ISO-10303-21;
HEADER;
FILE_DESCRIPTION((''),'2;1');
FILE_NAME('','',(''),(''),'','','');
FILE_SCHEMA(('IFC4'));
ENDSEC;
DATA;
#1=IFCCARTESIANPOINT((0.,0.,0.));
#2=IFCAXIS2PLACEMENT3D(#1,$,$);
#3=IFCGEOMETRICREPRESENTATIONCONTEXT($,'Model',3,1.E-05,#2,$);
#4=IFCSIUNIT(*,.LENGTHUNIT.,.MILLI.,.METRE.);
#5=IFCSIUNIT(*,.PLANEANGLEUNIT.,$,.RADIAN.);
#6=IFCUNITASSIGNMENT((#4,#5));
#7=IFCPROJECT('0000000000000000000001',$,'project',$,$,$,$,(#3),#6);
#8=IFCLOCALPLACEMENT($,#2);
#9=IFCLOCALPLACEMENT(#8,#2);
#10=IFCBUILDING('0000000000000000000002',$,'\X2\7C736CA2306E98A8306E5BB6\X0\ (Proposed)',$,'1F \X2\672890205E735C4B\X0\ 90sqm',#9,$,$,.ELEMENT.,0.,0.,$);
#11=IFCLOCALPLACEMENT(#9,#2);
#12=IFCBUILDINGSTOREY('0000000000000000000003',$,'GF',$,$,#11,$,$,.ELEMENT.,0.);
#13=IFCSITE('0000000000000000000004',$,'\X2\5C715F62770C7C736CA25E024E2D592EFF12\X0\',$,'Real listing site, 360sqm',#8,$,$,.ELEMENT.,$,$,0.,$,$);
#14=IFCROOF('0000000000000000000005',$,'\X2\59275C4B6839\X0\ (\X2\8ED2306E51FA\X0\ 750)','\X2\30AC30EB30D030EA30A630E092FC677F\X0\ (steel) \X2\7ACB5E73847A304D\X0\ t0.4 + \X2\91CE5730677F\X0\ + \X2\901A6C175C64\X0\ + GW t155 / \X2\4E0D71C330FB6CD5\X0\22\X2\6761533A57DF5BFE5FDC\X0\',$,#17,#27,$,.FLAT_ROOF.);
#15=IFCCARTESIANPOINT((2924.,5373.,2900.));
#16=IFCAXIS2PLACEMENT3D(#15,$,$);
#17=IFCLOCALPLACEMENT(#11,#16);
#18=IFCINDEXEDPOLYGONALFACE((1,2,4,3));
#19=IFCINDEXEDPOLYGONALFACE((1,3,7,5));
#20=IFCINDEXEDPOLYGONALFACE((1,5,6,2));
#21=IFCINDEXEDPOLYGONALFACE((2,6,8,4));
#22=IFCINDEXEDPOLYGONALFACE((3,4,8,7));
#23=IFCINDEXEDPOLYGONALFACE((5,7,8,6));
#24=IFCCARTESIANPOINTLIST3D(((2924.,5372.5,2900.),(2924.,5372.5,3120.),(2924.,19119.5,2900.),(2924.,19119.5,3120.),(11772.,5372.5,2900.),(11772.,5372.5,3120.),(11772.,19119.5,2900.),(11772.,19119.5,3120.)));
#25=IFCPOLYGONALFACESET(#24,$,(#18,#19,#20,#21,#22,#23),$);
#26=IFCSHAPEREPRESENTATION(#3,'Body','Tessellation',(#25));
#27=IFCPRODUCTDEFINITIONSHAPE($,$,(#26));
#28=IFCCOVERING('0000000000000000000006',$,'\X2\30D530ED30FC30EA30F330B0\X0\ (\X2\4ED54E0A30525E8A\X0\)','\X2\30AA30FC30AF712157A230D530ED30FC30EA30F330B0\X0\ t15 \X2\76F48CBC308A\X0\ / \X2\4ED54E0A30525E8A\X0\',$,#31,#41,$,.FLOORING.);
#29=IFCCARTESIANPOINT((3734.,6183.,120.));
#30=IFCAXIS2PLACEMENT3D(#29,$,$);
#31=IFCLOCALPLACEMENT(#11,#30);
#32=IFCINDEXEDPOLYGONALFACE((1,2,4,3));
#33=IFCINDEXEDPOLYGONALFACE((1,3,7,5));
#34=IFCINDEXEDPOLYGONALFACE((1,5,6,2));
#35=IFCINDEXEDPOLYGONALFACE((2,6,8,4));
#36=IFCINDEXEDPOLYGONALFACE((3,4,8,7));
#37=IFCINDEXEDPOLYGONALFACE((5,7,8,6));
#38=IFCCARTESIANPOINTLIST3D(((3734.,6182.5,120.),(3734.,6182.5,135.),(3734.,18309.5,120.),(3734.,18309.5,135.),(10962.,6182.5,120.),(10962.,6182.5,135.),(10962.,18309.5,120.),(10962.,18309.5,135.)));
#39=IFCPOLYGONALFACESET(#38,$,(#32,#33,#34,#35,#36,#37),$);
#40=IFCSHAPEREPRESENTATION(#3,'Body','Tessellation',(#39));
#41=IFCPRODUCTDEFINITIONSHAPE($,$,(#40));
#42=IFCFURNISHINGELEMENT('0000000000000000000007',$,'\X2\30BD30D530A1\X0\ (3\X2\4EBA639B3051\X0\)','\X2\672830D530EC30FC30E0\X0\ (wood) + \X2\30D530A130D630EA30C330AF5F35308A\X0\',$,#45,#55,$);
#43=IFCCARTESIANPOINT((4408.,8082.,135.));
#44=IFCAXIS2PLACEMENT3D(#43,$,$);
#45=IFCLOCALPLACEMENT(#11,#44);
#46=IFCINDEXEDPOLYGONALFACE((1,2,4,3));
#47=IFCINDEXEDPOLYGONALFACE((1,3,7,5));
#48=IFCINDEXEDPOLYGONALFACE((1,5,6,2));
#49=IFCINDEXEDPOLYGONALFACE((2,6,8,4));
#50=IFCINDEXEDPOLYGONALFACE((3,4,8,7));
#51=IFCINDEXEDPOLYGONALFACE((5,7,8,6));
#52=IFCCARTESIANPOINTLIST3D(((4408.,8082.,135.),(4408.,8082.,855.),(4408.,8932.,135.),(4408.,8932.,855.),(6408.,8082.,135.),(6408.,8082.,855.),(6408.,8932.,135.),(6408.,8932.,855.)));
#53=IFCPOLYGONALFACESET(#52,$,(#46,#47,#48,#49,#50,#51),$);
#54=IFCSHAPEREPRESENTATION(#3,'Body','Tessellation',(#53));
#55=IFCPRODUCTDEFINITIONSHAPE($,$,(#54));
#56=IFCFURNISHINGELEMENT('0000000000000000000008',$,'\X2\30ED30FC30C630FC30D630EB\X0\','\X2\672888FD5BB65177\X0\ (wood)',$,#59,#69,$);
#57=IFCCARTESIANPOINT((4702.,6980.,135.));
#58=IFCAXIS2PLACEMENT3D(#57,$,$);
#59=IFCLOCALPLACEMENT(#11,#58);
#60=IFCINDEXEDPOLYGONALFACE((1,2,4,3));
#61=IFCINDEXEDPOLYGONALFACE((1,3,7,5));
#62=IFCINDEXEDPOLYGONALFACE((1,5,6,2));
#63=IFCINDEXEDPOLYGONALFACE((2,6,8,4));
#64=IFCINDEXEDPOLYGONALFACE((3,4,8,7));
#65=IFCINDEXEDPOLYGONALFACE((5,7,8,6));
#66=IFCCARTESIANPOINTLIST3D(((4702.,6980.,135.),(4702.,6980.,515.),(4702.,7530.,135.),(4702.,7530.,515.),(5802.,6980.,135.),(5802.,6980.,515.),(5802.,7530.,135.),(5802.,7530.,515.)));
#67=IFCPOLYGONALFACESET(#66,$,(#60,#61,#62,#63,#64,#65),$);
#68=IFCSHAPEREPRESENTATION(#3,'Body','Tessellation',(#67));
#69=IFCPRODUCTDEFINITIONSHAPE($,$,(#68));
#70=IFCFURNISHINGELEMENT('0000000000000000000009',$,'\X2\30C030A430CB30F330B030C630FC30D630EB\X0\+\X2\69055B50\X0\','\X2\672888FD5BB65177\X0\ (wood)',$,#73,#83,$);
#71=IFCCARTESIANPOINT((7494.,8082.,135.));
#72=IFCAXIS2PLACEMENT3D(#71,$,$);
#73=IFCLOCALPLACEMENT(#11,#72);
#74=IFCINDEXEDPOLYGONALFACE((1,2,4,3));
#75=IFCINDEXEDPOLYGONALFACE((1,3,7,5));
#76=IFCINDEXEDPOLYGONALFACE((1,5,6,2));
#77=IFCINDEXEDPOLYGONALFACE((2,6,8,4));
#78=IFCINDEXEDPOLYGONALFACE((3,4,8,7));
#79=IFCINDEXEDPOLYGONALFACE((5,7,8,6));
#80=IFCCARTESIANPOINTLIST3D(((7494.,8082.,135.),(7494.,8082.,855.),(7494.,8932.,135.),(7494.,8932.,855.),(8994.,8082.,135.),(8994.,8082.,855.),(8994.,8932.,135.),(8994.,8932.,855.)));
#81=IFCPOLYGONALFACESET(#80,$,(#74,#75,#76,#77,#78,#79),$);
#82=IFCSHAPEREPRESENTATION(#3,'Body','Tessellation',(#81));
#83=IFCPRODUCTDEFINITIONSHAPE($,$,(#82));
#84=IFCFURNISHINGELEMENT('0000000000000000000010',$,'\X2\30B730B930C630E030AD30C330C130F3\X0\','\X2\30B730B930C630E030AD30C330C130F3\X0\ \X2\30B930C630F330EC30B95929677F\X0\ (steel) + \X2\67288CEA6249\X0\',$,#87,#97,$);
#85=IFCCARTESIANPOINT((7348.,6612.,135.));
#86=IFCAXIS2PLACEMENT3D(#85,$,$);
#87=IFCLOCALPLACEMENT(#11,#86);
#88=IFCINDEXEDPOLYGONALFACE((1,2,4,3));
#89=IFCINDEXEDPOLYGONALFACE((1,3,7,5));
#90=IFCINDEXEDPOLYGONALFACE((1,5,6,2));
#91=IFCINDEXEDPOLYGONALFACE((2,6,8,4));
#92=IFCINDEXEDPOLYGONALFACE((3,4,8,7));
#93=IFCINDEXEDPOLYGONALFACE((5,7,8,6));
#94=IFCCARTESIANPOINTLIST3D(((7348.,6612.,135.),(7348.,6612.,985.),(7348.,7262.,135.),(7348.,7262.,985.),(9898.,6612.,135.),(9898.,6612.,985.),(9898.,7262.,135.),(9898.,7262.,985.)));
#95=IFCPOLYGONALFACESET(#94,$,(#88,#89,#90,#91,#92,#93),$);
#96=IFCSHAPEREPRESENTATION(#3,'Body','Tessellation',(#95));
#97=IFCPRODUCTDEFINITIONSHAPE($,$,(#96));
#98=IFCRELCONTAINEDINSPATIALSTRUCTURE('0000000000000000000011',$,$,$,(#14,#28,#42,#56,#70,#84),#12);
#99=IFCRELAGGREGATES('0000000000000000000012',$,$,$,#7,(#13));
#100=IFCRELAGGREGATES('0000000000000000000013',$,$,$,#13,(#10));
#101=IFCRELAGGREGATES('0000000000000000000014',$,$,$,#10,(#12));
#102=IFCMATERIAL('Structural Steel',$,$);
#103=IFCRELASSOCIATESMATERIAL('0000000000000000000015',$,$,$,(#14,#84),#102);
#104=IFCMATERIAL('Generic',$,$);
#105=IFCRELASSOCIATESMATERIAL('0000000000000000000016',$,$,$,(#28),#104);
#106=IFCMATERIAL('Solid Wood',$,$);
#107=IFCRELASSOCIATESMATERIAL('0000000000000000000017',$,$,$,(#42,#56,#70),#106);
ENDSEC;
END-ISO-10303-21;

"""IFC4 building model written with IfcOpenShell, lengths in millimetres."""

from ifc_helpers import new_model, si_unit, frame, frame_2d, origin, place, context, project, spatial, rectangle, extrude, material, element, save


model = new_model("IFC4")

# Units and contexts
model_context = context("Model", 3, precision=1e-05, world=origin())
ifc_project = project(units=[si_unit("LENGTHUNIT", "METRE", prefix="MILLI"), si_unit("PLANEANGLEUNIT", "RADIAN")], contexts=[model_context])

# Site, building, storey
site_placement = place(None, origin())
site = spatial("IfcSite", under=ifc_project, at=site_placement, Name="山形県米沢市中央２", ObjectType="Real listing site, 360sqm", CompositionType="ELEMENT", RefElevation=0.0)
building_placement = place(site_placement, origin())
building = spatial("IfcBuilding", under=site, at=building_placement, Name="米沢の風の家 (Proposed)", ObjectType="1F 木造平屋 90sqm", CompositionType="ELEMENT", ElevationOfRefHeight=0.0, ElevationOfTerrain=0.0)
storey_placement = place(building_placement, origin())
storey = spatial("IfcBuildingStorey", under=building, at=storey_placement, Name="GF", CompositionType="ELEMENT", Elevation=0.0)

# Shared definitions
ifc_material_1 = material(Name="Solid Wood")

# Roof
ifc_material_2 = material(Name="Structural Steel")
roof_placement = place(storey_placement, frame((2924.0, 5373.0, 2900.0)))
element("IfcRoof", 1, at=roof_placement, inside=storey, material=ifc_material_2, Name="大屋根 (軒の出 750)", Description="ガルバリウム鋼板 (steel) 立平葺き t0.4 + 野地板 + 通気層 + GW t155 / 不燃・法22条区域対応", PredefinedType="FLAT_ROOF", context=model_context, shape_type="SweptSolid", body=[
    extrude(rectangle(XDim=8848.0, YDim=13747.0, at=frame_2d((4424.0, 6873.0))), frame((2924.0, 5373.0, 2900.0)), (0.0, 0.0, 1.0), 220.0),
])

# Covering
ifc_material_3 = material(Name="Generic")
covering_placement = place(storey_placement, frame((3734.0, 6183.0, 120.0)))
element("IfcCovering", 2, at=covering_placement, inside=storey, material=ifc_material_3, Name="フローリング (仕上げ床)", Description="オーク無垢フローリング t15 直貼り / 仕上げ床", PredefinedType="FLOORING", context=model_context, shape_type="SweptSolid", body=[
    extrude(rectangle(XDim=7228.0, YDim=12127.0, at=frame_2d((3614.0, 6063.0))), frame((3734.0, 6183.0, 120.0)), (0.0, 0.0, 1.0), 15.0),
])

# Furnishing elements
furnishing_1_placement = place(storey_placement, frame((4408.0, 8082.0, 135.0)))
element("IfcFurnishingElement", 3, at=furnishing_1_placement, inside=storey, material=ifc_material_1, Name="ソファ (3人掛け)", Description="木フレーム (wood) + ファブリック張り", context=model_context, shape_type="SweptSolid", body=[
    extrude(rectangle(XDim=2000.0, YDim=850.0, at=frame_2d((1000.0, 425.0))), frame((4408.0, 8082.0, 135.0)), (0.0, 0.0, 1.0), 720.0),
])
furnishing_2_placement = place(storey_placement, frame((4702.0, 6980.0, 135.0)))
element("IfcFurnishingElement", 4, at=furnishing_2_placement, inside=storey, material=ifc_material_1, Name="ローテーブル", Description="木製家具 (wood)", context=model_context, shape_type="SweptSolid", body=[
    extrude(rectangle(XDim=1100.0, YDim=550.0, at=frame_2d((550.0, 275.0))), frame((4702.0, 6980.0, 135.0)), (0.0, 0.0, 1.0), 380.0),
])
furnishing_3_placement = place(storey_placement, frame((7494.0, 8082.0, 135.0)))
element("IfcFurnishingElement", 5, at=furnishing_3_placement, inside=storey, material=ifc_material_1, Name="ダイニングテーブル+椅子", Description="木製家具 (wood)", context=model_context, shape_type="SweptSolid", body=[
    extrude(rectangle(XDim=1500.0, YDim=850.0, at=frame_2d((750.0, 425.0))), frame((7494.0, 8082.0, 135.0)), (0.0, 0.0, 1.0), 720.0),
])
furnishing_4_placement = place(storey_placement, frame((7348.0, 6612.0, 135.0)))
element("IfcFurnishingElement", 6, at=furnishing_4_placement, inside=storey, material=ifc_material_2, Name="システムキッチン", Description="システムキッチン ステンレス天板 (steel) + 木質扉", context=model_context, shape_type="SweptSolid", body=[
    extrude(rectangle(XDim=2550.0, YDim=650.0, at=frame_2d((1275.0, 325.0))), frame((7348.0, 6612.0, 135.0)), (0.0, 0.0, 1.0), 850.0),
])

save(model, "model.ifc")
